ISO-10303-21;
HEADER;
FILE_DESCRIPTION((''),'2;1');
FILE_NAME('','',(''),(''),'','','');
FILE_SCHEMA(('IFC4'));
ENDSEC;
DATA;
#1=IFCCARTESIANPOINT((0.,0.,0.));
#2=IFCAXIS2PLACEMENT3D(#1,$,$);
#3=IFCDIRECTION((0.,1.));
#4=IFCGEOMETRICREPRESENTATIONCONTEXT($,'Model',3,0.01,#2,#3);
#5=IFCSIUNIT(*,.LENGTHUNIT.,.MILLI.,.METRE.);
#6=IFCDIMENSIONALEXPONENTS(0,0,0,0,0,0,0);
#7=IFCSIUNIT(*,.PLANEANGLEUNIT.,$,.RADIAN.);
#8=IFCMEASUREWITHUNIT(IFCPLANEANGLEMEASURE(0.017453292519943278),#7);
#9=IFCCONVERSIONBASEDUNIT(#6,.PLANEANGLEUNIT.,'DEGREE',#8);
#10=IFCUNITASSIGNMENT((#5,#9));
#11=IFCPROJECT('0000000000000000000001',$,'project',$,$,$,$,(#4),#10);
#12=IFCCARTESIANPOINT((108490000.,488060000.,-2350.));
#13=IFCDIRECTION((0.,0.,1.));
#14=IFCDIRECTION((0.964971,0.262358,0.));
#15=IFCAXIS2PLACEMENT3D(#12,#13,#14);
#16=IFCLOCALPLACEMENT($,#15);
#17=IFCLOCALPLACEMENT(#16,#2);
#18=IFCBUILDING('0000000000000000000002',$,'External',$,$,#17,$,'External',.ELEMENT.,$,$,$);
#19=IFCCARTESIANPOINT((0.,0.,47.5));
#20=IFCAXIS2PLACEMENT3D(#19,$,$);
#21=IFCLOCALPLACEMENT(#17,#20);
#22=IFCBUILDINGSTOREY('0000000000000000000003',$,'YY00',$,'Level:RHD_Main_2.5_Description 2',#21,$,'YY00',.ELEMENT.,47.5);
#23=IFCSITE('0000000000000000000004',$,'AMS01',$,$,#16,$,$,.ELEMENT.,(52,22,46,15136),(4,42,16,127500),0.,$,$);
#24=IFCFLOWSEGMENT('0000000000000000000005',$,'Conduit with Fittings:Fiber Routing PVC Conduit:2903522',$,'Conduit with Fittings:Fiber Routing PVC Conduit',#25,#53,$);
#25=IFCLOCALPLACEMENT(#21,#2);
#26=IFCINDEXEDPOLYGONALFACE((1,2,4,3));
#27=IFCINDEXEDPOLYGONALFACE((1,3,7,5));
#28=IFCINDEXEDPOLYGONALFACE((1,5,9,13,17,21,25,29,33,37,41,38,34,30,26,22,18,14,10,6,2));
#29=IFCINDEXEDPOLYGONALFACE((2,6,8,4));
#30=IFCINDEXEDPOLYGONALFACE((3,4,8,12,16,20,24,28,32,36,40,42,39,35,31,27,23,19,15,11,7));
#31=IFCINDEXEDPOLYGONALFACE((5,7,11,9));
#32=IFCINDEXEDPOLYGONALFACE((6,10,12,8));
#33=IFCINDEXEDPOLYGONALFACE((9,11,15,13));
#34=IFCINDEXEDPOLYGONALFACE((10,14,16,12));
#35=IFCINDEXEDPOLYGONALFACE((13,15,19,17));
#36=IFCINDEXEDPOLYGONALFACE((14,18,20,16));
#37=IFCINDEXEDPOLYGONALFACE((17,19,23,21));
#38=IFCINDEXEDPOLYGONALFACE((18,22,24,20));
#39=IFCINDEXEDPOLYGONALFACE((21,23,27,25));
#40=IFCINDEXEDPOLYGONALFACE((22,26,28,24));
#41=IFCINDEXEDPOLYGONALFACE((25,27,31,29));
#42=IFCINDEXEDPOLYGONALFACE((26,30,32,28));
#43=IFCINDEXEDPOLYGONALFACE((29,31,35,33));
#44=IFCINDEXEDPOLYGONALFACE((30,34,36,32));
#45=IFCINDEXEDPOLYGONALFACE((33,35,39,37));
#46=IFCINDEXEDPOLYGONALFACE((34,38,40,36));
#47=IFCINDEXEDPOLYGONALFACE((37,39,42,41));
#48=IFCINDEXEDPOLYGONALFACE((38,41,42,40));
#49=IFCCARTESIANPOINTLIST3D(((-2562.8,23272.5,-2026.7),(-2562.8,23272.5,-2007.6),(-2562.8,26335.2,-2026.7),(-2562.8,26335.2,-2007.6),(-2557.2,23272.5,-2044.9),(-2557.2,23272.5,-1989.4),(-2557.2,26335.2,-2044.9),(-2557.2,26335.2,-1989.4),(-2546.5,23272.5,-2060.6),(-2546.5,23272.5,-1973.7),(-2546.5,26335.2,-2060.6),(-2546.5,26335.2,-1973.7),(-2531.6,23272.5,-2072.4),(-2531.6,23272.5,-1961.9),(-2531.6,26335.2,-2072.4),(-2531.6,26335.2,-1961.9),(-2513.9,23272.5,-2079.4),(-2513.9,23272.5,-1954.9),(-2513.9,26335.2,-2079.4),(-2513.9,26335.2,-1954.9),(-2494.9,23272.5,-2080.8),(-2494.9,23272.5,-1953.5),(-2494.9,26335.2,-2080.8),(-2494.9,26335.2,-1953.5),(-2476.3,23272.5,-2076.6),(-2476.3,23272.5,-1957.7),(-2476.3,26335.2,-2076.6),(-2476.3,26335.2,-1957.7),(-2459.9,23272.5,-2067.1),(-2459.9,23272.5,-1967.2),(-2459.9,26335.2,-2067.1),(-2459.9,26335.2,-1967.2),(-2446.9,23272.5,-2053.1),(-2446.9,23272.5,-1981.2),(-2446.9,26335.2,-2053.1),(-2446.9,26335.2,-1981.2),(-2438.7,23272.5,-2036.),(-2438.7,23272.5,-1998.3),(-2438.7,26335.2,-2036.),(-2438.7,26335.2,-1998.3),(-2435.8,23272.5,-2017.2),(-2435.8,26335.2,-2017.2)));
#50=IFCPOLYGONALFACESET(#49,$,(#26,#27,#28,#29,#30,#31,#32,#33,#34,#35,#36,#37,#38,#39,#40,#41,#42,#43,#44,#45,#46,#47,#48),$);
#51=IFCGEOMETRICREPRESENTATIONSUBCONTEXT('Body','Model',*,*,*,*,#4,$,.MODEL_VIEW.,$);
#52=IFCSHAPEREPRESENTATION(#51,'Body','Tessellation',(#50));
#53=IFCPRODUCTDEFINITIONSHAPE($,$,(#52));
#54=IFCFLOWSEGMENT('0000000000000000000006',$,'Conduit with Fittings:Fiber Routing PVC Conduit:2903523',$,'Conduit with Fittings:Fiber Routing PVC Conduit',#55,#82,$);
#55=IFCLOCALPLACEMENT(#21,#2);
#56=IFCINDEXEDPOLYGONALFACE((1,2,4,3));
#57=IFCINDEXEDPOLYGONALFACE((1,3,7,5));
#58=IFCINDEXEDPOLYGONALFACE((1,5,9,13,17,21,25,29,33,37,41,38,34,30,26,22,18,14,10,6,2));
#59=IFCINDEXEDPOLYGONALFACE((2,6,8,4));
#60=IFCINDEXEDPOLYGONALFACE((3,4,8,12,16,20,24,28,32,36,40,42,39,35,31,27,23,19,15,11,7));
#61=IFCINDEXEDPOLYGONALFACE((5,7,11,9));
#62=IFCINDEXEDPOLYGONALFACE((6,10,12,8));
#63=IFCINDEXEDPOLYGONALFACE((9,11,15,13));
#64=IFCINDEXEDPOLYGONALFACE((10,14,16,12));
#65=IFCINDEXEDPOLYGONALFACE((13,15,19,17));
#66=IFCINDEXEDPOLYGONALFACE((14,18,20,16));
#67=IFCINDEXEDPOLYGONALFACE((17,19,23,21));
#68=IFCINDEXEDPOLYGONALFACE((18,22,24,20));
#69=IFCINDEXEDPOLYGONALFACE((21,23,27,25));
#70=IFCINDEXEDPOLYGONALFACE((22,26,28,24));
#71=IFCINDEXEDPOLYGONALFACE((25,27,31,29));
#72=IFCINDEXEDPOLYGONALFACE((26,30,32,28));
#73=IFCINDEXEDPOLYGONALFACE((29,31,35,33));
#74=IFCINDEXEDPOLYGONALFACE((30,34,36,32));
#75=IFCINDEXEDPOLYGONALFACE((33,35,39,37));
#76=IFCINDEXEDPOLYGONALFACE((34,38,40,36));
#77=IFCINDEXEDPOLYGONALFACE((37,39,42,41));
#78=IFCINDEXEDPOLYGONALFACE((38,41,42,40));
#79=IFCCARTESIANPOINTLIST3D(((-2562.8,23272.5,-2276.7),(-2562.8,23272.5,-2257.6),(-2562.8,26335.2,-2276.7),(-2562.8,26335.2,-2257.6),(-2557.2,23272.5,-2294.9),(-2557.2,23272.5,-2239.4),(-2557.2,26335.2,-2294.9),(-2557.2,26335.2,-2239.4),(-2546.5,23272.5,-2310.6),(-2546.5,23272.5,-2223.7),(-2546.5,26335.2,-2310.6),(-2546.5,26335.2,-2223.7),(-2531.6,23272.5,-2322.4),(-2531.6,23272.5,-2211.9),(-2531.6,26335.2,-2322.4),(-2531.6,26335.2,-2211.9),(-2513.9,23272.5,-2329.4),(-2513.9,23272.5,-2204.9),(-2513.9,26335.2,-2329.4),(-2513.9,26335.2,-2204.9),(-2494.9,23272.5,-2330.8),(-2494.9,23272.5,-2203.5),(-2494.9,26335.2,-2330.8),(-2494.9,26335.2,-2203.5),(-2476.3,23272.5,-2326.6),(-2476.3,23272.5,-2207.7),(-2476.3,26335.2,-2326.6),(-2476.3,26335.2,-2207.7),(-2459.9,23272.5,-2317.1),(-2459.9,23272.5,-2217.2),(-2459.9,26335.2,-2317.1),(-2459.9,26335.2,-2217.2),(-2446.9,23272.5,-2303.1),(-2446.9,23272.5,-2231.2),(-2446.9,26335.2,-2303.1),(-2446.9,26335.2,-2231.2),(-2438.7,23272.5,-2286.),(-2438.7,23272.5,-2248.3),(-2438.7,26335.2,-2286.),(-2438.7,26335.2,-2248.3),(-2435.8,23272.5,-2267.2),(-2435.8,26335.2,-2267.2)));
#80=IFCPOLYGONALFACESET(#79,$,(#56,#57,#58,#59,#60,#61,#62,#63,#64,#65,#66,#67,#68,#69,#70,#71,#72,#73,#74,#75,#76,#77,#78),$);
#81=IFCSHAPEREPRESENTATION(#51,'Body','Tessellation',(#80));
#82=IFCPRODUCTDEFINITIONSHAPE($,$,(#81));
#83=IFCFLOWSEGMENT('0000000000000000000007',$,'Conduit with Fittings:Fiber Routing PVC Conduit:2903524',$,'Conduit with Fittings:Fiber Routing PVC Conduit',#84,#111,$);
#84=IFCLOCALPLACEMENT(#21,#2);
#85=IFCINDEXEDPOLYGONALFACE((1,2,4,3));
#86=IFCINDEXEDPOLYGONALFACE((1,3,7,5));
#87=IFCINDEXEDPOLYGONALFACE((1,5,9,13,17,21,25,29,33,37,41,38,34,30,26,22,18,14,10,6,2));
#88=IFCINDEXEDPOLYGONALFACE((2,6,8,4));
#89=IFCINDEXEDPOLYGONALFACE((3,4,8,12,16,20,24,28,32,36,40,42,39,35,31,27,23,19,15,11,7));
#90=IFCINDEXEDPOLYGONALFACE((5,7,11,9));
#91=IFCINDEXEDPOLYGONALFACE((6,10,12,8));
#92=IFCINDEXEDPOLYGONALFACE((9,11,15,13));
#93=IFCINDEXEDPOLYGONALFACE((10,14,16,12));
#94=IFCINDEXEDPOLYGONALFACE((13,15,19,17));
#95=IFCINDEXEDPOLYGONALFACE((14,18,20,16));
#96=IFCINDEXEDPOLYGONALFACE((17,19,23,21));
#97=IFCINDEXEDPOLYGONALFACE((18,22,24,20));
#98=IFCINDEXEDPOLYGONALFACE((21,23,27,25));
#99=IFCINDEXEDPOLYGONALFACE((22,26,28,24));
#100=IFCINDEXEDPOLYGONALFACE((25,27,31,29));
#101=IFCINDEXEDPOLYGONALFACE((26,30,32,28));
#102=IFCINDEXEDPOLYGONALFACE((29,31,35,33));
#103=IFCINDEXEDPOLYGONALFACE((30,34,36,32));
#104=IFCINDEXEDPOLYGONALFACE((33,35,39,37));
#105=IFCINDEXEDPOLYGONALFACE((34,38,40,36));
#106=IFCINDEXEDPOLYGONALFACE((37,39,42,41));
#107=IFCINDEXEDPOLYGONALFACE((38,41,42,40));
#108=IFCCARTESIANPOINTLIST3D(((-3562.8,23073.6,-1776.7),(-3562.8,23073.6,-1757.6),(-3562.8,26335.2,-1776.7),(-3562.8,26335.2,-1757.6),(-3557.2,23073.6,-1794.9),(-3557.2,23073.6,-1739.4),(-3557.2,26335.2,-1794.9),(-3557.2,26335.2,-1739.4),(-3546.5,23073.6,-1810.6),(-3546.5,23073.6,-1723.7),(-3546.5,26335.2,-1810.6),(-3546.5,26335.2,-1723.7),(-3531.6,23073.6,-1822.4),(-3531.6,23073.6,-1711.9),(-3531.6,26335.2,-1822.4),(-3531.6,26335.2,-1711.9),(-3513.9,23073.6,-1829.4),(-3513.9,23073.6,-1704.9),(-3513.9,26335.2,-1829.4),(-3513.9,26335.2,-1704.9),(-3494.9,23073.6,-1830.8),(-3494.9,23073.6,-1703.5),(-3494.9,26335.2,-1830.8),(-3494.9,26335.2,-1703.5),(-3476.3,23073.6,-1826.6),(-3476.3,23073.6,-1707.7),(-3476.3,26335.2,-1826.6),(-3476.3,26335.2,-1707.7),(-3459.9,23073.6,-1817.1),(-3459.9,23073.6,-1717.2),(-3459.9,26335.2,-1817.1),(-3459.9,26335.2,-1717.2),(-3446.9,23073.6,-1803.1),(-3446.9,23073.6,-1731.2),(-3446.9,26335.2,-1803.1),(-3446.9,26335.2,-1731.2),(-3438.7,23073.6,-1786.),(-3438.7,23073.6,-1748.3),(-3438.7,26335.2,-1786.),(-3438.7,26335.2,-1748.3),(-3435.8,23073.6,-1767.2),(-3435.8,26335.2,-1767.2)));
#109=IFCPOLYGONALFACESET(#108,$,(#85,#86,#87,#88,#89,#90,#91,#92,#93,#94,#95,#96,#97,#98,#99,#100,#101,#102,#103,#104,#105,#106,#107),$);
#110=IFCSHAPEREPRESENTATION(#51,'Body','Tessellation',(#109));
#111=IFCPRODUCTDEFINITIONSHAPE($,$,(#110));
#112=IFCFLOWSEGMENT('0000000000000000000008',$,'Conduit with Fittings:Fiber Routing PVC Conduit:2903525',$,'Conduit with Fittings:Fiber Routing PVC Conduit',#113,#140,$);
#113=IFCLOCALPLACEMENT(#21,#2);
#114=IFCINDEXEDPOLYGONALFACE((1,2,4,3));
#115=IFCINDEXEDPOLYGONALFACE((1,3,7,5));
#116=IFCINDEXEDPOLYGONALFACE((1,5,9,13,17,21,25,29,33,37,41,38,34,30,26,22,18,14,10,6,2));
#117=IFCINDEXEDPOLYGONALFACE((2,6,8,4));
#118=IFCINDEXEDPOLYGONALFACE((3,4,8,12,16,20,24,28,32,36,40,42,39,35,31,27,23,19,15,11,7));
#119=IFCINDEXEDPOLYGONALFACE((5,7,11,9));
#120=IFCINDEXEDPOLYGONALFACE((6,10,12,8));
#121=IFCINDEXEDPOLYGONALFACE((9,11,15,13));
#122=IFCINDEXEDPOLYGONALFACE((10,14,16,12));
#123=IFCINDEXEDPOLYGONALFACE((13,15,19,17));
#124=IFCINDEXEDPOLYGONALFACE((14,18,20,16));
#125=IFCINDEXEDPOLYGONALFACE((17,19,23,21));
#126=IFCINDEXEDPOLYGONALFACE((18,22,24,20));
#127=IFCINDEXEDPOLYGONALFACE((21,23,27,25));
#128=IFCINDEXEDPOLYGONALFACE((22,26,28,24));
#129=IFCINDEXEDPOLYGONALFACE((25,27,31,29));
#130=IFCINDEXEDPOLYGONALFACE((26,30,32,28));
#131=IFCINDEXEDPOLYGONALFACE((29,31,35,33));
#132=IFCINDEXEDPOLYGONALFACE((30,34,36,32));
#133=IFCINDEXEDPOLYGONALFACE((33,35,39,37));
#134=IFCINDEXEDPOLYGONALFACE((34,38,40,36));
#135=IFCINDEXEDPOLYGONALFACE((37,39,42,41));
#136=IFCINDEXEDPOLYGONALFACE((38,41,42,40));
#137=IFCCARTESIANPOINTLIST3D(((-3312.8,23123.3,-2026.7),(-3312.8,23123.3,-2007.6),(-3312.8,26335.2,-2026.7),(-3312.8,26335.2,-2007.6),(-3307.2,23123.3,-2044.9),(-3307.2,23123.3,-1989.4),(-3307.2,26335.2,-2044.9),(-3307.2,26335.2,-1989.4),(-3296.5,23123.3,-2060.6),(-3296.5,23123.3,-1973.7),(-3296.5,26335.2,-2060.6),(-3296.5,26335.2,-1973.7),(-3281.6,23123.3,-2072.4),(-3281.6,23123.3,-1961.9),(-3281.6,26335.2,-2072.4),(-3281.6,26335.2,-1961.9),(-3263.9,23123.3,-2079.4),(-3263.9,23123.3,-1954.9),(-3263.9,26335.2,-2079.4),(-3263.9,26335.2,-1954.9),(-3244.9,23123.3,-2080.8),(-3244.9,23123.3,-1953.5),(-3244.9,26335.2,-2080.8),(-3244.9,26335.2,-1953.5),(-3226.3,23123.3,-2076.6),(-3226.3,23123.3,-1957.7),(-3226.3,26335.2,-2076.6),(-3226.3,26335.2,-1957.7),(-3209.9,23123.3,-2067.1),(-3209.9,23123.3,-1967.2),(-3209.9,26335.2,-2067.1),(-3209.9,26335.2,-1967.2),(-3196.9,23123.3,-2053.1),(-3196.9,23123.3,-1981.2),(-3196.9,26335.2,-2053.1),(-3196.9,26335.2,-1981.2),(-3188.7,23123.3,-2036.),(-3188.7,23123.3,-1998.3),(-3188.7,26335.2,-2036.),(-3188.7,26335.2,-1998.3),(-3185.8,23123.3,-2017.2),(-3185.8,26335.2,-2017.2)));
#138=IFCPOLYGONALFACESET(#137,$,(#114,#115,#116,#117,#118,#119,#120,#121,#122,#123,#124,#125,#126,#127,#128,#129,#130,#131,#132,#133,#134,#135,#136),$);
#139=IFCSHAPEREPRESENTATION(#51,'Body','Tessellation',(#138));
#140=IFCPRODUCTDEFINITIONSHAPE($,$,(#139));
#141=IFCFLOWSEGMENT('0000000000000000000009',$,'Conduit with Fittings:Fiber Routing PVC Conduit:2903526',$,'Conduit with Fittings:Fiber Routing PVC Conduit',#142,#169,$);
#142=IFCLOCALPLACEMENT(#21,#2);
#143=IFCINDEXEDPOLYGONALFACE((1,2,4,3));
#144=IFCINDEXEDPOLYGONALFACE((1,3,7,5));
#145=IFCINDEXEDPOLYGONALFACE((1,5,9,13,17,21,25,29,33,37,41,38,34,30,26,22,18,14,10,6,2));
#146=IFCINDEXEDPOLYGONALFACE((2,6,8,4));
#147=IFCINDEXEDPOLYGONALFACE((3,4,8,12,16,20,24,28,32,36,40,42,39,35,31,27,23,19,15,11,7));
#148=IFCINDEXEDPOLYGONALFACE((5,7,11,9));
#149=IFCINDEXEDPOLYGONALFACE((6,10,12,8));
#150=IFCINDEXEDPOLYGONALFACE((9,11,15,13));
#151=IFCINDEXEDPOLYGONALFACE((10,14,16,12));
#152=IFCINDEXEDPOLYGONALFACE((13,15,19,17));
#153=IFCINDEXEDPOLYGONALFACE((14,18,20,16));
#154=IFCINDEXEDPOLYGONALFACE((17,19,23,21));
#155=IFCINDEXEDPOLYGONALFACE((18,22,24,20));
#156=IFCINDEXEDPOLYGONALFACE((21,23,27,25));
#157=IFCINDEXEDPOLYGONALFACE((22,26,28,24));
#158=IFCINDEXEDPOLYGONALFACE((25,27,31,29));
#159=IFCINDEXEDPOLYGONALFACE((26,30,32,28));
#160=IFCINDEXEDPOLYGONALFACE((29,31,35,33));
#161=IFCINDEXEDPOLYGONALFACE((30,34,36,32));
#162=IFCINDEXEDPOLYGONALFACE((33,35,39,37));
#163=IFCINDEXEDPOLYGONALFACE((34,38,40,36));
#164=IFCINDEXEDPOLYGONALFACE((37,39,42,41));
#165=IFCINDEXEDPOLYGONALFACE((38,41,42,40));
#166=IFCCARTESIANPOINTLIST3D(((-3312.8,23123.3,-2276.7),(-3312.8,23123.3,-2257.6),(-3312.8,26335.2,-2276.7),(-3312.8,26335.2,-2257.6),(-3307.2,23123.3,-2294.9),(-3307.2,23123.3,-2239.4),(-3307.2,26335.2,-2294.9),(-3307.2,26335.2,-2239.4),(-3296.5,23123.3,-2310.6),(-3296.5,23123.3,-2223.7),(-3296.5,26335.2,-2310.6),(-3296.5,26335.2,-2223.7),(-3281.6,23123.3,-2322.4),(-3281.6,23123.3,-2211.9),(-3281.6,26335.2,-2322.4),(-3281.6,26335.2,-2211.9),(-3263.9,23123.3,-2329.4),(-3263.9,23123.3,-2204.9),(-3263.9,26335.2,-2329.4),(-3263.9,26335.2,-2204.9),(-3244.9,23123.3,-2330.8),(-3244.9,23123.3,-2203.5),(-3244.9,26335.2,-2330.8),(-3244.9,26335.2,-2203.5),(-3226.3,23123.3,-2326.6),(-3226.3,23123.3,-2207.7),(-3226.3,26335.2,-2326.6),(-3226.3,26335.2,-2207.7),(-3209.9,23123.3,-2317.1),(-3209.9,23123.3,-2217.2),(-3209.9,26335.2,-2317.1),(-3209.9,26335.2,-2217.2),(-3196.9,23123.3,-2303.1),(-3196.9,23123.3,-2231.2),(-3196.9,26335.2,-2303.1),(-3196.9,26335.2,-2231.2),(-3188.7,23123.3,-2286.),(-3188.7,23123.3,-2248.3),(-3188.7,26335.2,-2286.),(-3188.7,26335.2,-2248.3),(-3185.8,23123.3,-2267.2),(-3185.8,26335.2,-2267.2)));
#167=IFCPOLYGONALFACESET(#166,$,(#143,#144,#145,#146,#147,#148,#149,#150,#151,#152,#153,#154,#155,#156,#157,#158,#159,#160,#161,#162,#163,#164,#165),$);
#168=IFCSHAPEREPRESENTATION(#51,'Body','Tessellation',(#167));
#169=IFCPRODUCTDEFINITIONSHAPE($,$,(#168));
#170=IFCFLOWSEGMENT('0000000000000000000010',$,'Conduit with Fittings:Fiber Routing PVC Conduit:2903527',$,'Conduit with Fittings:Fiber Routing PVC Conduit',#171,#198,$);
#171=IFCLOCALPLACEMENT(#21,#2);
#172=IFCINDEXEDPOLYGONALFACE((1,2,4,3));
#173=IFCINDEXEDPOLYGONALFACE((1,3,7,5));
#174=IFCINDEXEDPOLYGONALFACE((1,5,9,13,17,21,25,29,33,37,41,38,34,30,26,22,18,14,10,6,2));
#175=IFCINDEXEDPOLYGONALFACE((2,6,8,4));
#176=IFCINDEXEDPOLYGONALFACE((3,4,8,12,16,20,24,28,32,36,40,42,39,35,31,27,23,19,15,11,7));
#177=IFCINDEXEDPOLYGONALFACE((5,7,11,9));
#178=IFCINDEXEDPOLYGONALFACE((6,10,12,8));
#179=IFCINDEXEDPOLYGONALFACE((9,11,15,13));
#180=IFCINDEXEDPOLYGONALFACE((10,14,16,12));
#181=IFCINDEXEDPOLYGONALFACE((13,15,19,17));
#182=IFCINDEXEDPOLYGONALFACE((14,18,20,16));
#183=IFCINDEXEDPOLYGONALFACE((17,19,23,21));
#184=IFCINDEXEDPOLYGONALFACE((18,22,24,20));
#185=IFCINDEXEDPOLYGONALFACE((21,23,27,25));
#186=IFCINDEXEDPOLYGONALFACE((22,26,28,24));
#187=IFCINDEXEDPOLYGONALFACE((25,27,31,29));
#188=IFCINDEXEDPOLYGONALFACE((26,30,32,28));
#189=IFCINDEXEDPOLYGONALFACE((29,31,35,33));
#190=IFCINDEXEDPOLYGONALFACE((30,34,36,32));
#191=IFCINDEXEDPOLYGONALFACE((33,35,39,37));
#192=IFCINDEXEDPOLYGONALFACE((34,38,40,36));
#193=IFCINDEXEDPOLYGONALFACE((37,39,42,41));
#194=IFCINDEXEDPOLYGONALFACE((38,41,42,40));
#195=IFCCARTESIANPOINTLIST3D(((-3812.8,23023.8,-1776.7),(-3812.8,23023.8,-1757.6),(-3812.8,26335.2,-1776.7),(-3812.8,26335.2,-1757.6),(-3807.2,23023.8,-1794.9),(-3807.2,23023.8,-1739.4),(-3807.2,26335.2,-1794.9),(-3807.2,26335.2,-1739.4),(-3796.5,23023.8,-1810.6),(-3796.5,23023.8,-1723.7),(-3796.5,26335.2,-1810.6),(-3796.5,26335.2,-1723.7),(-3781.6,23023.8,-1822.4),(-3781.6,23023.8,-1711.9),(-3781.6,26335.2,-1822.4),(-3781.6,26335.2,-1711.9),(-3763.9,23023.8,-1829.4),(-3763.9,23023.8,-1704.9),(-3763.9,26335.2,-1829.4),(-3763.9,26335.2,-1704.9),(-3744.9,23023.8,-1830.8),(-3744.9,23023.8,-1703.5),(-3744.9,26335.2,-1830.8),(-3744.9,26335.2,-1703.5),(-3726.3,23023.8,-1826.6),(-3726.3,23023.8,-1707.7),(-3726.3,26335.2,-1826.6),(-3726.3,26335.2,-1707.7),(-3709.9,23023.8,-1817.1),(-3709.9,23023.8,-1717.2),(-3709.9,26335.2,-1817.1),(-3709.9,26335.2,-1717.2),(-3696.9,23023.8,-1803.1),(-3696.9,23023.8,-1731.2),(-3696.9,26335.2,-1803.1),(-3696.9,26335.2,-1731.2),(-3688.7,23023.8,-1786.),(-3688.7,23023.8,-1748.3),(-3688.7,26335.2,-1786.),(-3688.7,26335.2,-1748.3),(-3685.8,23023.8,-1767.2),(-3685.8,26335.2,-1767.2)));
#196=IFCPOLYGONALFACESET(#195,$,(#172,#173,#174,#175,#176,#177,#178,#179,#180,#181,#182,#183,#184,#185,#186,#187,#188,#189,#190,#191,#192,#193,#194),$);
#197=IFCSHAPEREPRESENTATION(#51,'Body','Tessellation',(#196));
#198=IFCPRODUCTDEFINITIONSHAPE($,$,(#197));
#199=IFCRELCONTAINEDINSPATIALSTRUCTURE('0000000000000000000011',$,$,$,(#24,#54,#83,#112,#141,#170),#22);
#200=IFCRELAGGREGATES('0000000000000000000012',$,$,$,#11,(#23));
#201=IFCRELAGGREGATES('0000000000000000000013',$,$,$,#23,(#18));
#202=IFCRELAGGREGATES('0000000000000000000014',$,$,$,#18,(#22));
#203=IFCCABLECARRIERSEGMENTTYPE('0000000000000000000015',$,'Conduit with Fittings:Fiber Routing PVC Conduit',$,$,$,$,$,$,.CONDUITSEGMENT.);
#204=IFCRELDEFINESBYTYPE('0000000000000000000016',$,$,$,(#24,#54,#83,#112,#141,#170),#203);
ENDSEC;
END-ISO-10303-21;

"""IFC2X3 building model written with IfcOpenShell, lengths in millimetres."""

from ifc_helpers import new_model, entity, si_unit, converted_unit, direction, frame, frame_2d, origin, origin_2d_with_axis, place, context, subcontext, project, spatial, circle, extrude, type_object, element, save


model = new_model("IFC2X3")

# Units and contexts
model_context = context("Model", 3, precision=0.01, world=origin(), true_north=direction((0.0, 1.0)))
body_context = subcontext(model_context, "Body", "Model", "MODEL_VIEW")
ifc_project = project(units=[si_unit("LENGTHUNIT", "METRE", prefix="MILLI"), converted_unit("PLANEANGLEUNIT", "DEGREE", entity("IfcPlaneAngleMeasure", 0.017453292519943278), si_unit("PLANEANGLEUNIT", "RADIAN"), dimensions=[0, 0, 0, 0, 0, 0, 0])], contexts=[model_context])

# Site, building, storey
site_placement = place(None, frame((108490000.0, 488060000.0, -2350.0), z_axis=(0.0, 0.0, 1.0), x_axis=(0.964971, 0.262358, 0.0)))
site = spatial("IfcSite", under=ifc_project, at=site_placement, Name="AMS01", CompositionType="ELEMENT", RefLatitude=(52, 22, 46, 15136), RefLongitude=(4, 42, 16, 127500), RefElevation=0.0)
building_placement = place(site_placement, origin())
building = spatial("IfcBuilding", under=site, at=building_placement, Name="External", LongName="External", CompositionType="ELEMENT")
storey_placement = place(building_placement, frame((0.0, 0.0, 47.5)))
storey = spatial("IfcBuildingStorey", under=building, at=storey_placement, Name="YY00", ObjectType="Level:RHD_Main_2.5_Description 2", LongName="YY00", CompositionType="ELEMENT", Elevation=47.5)

# Flow segments
cable_carrier_segment_type = type_object("IfcCableCarrierSegmentType", Name="Conduit with Fittings:Fiber Routing PVC Conduit", PredefinedType="CONDUITSEGMENT")
flow_segment_1_placement = place(storey_placement, origin())
element("IfcFlowSegment", 1, at=flow_segment_1_placement, inside=storey, type_object=cable_carrier_segment_type, Name="Conduit with Fittings:Fiber Routing PVC Conduit:2903522", ObjectType="Conduit with Fittings:Fiber Routing PVC Conduit", context=body_context, shape_type="SweptSolid", body=[
    extrude(circle(Radius=63.9, at=frame_2d((0.0, 0.0), x_axis=(1.0, 0.0))), frame((-2499.7, 23272.5, -2017.2), z_axis=(0.0, 1.0, 0.0), x_axis=(1.0, 0.0, 0.0)), (0.0, 0.0, 1.0), 3062.7),
])
flow_segment_2_placement = place(storey_placement, origin())
element("IfcFlowSegment", 2, at=flow_segment_2_placement, inside=storey, type_object=cable_carrier_segment_type, Name="Conduit with Fittings:Fiber Routing PVC Conduit:2903523", ObjectType="Conduit with Fittings:Fiber Routing PVC Conduit", context=body_context, shape_type="SweptSolid", body=[
    extrude(circle(Radius=63.9, at=frame_2d((0.0, 0.0), x_axis=(1.0, 0.0))), frame((-2499.7, 23272.5, -2267.2), z_axis=(0.0, 1.0, 0.0), x_axis=(1.0, 0.0, 0.0)), (0.0, 0.0, 1.0), 3062.7),
])
flow_segment_3_placement = place(storey_placement, origin())
element("IfcFlowSegment", 3, at=flow_segment_3_placement, inside=storey, type_object=cable_carrier_segment_type, Name="Conduit with Fittings:Fiber Routing PVC Conduit:2903524", ObjectType="Conduit with Fittings:Fiber Routing PVC Conduit", context=body_context, shape_type="SweptSolid", body=[
    extrude(circle(Radius=63.9, at=frame_2d((0.0, 0.0), x_axis=(1.0, 0.0))), frame((-3499.7, 23073.6, -1767.2), z_axis=(0.0, 1.0, 0.0), x_axis=(1.0, 0.0, 0.0)), (0.0, 0.0, 1.0), 3261.7),
])
flow_segment_4_placement = place(storey_placement, origin())
element("IfcFlowSegment", 4, at=flow_segment_4_placement, inside=storey, type_object=cable_carrier_segment_type, Name="Conduit with Fittings:Fiber Routing PVC Conduit:2903525", ObjectType="Conduit with Fittings:Fiber Routing PVC Conduit", context=body_context, shape_type="SweptSolid", body=[
    extrude(circle(Radius=63.9, at=frame_2d((0.0, 0.0), x_axis=(1.0, 0.0))), frame((-3249.7, 23123.3, -2017.2), z_axis=(0.0, 1.0, 0.0), x_axis=(1.0, 0.0, 0.0)), (0.0, 0.0, 1.0), 3211.9),
])
flow_segment_5_placement = place(storey_placement, origin())
element("IfcFlowSegment", 5, at=flow_segment_5_placement, inside=storey, type_object=cable_carrier_segment_type, Name="Conduit with Fittings:Fiber Routing PVC Conduit:2903526", ObjectType="Conduit with Fittings:Fiber Routing PVC Conduit", context=body_context, shape_type="SweptSolid", body=[
    extrude(circle(Radius=63.9, at=frame_2d((0.0, 0.0), x_axis=(1.0, 0.0))), frame((-3249.7, 23123.3, -2267.2), z_axis=(0.0, 1.0, 0.0), x_axis=(1.0, 0.0, 0.0)), (0.0, 0.0, 1.0), 3211.9),
])
flow_segment_6_placement = place(storey_placement, origin())
element("IfcFlowSegment", 6, at=flow_segment_6_placement, inside=storey, type_object=cable_carrier_segment_type, Name="Conduit with Fittings:Fiber Routing PVC Conduit:2903527", ObjectType="Conduit with Fittings:Fiber Routing PVC Conduit", context=body_context, shape_type="SweptSolid", body=[
    extrude(circle(Radius=63.9, at=origin_2d_with_axis()), frame((-3749.7, 23023.8, -1767.2), z_axis=(0.0, 1.0, 0.0), x_axis=(1.0, 0.0, 0.0)), (0.0, 0.0, 1.0), 3311.4),
])

save(model, "model.ifc")
